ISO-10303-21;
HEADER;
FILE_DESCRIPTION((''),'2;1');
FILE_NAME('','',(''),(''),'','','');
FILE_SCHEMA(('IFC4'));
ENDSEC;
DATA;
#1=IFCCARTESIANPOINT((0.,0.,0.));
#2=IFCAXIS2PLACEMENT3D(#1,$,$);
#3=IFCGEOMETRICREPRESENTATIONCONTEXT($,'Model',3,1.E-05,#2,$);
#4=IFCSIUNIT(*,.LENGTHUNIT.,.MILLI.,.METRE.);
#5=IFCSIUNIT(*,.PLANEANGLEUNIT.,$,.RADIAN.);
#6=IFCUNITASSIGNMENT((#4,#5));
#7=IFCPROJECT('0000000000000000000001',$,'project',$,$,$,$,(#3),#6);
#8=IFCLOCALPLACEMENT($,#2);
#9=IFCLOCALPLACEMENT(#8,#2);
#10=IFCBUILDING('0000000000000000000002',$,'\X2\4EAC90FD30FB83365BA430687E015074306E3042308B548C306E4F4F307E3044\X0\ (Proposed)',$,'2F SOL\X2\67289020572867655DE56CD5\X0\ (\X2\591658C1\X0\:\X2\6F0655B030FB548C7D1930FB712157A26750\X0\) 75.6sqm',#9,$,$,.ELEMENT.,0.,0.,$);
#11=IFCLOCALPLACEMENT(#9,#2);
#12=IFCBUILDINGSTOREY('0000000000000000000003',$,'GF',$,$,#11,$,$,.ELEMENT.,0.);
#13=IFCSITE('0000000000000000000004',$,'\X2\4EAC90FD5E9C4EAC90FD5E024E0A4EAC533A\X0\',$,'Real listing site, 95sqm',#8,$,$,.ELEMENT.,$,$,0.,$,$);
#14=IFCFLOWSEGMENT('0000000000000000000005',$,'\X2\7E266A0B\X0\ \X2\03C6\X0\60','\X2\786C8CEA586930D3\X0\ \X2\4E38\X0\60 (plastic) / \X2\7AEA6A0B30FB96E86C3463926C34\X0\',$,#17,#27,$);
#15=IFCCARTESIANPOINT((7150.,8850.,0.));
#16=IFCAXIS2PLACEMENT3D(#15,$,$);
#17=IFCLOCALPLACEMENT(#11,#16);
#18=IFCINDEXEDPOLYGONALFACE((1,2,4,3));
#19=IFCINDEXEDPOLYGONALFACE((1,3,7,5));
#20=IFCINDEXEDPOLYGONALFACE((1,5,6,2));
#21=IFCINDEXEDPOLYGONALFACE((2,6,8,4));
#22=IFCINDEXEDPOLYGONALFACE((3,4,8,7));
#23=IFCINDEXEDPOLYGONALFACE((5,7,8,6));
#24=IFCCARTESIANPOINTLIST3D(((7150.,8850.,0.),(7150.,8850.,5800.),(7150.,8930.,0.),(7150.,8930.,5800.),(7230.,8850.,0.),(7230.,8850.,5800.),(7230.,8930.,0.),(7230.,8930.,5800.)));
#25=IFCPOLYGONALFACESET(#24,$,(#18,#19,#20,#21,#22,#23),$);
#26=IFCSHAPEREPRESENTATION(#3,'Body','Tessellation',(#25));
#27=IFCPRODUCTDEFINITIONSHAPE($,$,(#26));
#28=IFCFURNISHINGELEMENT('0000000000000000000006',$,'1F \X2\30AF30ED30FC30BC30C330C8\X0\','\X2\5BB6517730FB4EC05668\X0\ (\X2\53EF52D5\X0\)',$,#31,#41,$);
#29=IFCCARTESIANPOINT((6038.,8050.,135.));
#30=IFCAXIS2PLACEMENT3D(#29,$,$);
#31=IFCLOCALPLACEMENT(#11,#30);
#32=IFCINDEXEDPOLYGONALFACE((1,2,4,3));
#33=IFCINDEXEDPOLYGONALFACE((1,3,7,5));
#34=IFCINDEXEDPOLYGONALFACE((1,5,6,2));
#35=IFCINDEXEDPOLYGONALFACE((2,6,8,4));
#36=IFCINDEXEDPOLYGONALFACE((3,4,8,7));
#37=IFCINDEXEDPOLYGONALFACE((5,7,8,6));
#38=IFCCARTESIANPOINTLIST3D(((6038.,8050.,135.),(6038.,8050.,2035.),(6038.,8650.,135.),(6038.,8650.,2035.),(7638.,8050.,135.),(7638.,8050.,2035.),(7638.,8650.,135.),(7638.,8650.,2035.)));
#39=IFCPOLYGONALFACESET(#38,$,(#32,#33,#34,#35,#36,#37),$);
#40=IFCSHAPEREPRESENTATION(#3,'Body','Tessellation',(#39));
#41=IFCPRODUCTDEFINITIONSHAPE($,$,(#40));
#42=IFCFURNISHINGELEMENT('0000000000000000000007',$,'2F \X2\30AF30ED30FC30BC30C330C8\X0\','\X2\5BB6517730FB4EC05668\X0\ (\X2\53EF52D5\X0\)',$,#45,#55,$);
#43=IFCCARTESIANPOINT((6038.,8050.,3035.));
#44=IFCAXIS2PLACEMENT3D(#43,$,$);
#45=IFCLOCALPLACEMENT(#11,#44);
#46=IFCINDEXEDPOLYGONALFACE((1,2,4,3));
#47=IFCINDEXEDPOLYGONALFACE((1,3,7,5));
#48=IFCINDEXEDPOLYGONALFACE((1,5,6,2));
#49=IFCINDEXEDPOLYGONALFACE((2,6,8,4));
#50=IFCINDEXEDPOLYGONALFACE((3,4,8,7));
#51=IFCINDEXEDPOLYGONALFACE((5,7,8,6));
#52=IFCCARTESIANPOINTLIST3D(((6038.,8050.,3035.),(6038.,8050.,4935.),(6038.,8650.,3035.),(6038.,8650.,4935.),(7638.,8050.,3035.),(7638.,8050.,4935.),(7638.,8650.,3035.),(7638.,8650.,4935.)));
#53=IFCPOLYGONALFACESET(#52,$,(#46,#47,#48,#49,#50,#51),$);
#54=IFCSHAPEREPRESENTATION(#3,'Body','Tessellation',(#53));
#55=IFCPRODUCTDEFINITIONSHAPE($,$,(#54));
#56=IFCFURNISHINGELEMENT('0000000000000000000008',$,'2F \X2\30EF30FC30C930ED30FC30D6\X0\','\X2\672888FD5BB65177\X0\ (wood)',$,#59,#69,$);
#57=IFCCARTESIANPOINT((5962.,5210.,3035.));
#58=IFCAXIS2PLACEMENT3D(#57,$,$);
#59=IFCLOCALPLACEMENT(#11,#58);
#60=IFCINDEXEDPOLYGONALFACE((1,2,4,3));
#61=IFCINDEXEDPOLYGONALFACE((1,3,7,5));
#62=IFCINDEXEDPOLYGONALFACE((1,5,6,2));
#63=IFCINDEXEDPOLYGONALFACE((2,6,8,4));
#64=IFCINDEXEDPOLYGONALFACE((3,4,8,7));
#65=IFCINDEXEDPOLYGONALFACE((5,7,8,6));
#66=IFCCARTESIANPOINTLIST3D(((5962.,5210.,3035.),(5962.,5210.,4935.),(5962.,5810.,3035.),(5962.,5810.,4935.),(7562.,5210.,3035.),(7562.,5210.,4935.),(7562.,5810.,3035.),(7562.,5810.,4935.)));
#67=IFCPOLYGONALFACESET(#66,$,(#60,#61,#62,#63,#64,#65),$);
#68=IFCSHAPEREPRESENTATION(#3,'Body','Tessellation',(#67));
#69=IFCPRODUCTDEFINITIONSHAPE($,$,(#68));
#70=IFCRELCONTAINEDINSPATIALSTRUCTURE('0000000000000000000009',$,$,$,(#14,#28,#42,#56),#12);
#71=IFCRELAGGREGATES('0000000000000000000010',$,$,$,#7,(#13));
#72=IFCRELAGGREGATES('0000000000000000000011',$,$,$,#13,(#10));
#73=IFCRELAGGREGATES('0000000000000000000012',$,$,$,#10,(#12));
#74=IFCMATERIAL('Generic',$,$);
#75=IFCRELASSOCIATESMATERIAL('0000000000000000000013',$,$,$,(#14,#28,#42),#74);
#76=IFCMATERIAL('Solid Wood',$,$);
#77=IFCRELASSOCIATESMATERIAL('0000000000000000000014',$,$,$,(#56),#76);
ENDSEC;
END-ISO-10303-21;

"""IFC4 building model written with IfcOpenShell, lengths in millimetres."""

from ifc_helpers import new_model, si_unit, frame, frame_2d, origin, place, context, project, spatial, rectangle, extrude, material, element, save


model = new_model("IFC4")

# Units and contexts
model_context = context("Model", 3, precision=1e-05, world=origin())
ifc_project = project(units=[si_unit("LENGTHUNIT", "METRE", prefix="MILLI"), si_unit("PLANEANGLEUNIT", "RADIAN")], contexts=[model_context])

# Site, building, storey
site_placement = place(None, origin())
site = spatial("IfcSite", under=ifc_project, at=site_placement, Name="京都府京都市上京区", ObjectType="Real listing site, 95sqm", CompositionType="ELEMENT", RefElevation=0.0)
building_placement = place(site_placement, origin())
building = spatial("IfcBuilding", under=site, at=building_placement, Name="京都・茶室と縁側のある和の住まい (Proposed)", ObjectType="2F SOL木造在来工法 (外壁:漆喰・和紙・無垢材) 75.6sqm", CompositionType="ELEMENT", ElevationOfRefHeight=0.0, ElevationOfTerrain=0.0)
storey_placement = place(building_placement, origin())
storey = spatial("IfcBuildingStorey", under=building, at=storey_placement, Name="GF", CompositionType="ELEMENT", Elevation=0.0)

# Shared definitions
ifc_material_1 = material(Name="Solid Wood")

# Shared definitions
ifc_material_2 = material(Name="Generic")

# Flow segment
flow_segment_placement = place(storey_placement, frame((7150.0, 8850.0, 0.0)))
element("IfcFlowSegment", 1, at=flow_segment_placement, inside=storey, material=ifc_material_2, Name="縦樋 φ60", Description="硬質塩ビ 丸60 (plastic) / 竪樋・雨水排水", context=model_context, shape_type="SweptSolid", body=[
    extrude(rectangle(XDim=80.0, YDim=80.0, at=frame_2d((40.0, 40.0))), frame((7150.0, 8850.0, 0.0)), (0.0, 0.0, 1.0), 5800.0),
])

# Furnishing elements
furnishing_1_placement = place(storey_placement, frame((6038.0, 8050.0, 135.0)))
element("IfcFurnishingElement", 2, at=furnishing_1_placement, inside=storey, material=ifc_material_2, Name="1F クローゼット", Description="家具・什器 (可動)", context=model_context, shape_type="SweptSolid", body=[
    extrude(rectangle(XDim=1600.0, YDim=600.0, at=frame_2d((800.0, 300.0))), frame((6038.0, 8050.0, 135.0)), (0.0, 0.0, 1.0), 1900.0),
])
furnishing_2_placement = place(storey_placement, frame((6038.0, 8050.0, 3035.0)))
element("IfcFurnishingElement", 3, at=furnishing_2_placement, inside=storey, material=ifc_material_2, Name="2F クローゼット", Description="家具・什器 (可動)", context=model_context, shape_type="SweptSolid", body=[
    extrude(rectangle(XDim=1600.0, YDim=600.0, at=frame_2d((800.0, 300.0))), frame((6038.0, 8050.0, 3035.0)), (0.0, 0.0, 1.0), 1900.0),
])
furnishing_3_placement = place(storey_placement, frame((5962.0, 5210.0, 3035.0)))
element("IfcFurnishingElement", 4, at=furnishing_3_placement, inside=storey, material=ifc_material_1, Name="2F ワードローブ", Description="木製家具 (wood)", context=model_context, shape_type="SweptSolid", body=[
    extrude(rectangle(XDim=1600.0, YDim=600.0, at=frame_2d((800.0, 300.0))), frame((5962.0, 5210.0, 3035.0)), (0.0, 0.0, 1.0), 1900.0),
])

save(model, "model.ifc")
